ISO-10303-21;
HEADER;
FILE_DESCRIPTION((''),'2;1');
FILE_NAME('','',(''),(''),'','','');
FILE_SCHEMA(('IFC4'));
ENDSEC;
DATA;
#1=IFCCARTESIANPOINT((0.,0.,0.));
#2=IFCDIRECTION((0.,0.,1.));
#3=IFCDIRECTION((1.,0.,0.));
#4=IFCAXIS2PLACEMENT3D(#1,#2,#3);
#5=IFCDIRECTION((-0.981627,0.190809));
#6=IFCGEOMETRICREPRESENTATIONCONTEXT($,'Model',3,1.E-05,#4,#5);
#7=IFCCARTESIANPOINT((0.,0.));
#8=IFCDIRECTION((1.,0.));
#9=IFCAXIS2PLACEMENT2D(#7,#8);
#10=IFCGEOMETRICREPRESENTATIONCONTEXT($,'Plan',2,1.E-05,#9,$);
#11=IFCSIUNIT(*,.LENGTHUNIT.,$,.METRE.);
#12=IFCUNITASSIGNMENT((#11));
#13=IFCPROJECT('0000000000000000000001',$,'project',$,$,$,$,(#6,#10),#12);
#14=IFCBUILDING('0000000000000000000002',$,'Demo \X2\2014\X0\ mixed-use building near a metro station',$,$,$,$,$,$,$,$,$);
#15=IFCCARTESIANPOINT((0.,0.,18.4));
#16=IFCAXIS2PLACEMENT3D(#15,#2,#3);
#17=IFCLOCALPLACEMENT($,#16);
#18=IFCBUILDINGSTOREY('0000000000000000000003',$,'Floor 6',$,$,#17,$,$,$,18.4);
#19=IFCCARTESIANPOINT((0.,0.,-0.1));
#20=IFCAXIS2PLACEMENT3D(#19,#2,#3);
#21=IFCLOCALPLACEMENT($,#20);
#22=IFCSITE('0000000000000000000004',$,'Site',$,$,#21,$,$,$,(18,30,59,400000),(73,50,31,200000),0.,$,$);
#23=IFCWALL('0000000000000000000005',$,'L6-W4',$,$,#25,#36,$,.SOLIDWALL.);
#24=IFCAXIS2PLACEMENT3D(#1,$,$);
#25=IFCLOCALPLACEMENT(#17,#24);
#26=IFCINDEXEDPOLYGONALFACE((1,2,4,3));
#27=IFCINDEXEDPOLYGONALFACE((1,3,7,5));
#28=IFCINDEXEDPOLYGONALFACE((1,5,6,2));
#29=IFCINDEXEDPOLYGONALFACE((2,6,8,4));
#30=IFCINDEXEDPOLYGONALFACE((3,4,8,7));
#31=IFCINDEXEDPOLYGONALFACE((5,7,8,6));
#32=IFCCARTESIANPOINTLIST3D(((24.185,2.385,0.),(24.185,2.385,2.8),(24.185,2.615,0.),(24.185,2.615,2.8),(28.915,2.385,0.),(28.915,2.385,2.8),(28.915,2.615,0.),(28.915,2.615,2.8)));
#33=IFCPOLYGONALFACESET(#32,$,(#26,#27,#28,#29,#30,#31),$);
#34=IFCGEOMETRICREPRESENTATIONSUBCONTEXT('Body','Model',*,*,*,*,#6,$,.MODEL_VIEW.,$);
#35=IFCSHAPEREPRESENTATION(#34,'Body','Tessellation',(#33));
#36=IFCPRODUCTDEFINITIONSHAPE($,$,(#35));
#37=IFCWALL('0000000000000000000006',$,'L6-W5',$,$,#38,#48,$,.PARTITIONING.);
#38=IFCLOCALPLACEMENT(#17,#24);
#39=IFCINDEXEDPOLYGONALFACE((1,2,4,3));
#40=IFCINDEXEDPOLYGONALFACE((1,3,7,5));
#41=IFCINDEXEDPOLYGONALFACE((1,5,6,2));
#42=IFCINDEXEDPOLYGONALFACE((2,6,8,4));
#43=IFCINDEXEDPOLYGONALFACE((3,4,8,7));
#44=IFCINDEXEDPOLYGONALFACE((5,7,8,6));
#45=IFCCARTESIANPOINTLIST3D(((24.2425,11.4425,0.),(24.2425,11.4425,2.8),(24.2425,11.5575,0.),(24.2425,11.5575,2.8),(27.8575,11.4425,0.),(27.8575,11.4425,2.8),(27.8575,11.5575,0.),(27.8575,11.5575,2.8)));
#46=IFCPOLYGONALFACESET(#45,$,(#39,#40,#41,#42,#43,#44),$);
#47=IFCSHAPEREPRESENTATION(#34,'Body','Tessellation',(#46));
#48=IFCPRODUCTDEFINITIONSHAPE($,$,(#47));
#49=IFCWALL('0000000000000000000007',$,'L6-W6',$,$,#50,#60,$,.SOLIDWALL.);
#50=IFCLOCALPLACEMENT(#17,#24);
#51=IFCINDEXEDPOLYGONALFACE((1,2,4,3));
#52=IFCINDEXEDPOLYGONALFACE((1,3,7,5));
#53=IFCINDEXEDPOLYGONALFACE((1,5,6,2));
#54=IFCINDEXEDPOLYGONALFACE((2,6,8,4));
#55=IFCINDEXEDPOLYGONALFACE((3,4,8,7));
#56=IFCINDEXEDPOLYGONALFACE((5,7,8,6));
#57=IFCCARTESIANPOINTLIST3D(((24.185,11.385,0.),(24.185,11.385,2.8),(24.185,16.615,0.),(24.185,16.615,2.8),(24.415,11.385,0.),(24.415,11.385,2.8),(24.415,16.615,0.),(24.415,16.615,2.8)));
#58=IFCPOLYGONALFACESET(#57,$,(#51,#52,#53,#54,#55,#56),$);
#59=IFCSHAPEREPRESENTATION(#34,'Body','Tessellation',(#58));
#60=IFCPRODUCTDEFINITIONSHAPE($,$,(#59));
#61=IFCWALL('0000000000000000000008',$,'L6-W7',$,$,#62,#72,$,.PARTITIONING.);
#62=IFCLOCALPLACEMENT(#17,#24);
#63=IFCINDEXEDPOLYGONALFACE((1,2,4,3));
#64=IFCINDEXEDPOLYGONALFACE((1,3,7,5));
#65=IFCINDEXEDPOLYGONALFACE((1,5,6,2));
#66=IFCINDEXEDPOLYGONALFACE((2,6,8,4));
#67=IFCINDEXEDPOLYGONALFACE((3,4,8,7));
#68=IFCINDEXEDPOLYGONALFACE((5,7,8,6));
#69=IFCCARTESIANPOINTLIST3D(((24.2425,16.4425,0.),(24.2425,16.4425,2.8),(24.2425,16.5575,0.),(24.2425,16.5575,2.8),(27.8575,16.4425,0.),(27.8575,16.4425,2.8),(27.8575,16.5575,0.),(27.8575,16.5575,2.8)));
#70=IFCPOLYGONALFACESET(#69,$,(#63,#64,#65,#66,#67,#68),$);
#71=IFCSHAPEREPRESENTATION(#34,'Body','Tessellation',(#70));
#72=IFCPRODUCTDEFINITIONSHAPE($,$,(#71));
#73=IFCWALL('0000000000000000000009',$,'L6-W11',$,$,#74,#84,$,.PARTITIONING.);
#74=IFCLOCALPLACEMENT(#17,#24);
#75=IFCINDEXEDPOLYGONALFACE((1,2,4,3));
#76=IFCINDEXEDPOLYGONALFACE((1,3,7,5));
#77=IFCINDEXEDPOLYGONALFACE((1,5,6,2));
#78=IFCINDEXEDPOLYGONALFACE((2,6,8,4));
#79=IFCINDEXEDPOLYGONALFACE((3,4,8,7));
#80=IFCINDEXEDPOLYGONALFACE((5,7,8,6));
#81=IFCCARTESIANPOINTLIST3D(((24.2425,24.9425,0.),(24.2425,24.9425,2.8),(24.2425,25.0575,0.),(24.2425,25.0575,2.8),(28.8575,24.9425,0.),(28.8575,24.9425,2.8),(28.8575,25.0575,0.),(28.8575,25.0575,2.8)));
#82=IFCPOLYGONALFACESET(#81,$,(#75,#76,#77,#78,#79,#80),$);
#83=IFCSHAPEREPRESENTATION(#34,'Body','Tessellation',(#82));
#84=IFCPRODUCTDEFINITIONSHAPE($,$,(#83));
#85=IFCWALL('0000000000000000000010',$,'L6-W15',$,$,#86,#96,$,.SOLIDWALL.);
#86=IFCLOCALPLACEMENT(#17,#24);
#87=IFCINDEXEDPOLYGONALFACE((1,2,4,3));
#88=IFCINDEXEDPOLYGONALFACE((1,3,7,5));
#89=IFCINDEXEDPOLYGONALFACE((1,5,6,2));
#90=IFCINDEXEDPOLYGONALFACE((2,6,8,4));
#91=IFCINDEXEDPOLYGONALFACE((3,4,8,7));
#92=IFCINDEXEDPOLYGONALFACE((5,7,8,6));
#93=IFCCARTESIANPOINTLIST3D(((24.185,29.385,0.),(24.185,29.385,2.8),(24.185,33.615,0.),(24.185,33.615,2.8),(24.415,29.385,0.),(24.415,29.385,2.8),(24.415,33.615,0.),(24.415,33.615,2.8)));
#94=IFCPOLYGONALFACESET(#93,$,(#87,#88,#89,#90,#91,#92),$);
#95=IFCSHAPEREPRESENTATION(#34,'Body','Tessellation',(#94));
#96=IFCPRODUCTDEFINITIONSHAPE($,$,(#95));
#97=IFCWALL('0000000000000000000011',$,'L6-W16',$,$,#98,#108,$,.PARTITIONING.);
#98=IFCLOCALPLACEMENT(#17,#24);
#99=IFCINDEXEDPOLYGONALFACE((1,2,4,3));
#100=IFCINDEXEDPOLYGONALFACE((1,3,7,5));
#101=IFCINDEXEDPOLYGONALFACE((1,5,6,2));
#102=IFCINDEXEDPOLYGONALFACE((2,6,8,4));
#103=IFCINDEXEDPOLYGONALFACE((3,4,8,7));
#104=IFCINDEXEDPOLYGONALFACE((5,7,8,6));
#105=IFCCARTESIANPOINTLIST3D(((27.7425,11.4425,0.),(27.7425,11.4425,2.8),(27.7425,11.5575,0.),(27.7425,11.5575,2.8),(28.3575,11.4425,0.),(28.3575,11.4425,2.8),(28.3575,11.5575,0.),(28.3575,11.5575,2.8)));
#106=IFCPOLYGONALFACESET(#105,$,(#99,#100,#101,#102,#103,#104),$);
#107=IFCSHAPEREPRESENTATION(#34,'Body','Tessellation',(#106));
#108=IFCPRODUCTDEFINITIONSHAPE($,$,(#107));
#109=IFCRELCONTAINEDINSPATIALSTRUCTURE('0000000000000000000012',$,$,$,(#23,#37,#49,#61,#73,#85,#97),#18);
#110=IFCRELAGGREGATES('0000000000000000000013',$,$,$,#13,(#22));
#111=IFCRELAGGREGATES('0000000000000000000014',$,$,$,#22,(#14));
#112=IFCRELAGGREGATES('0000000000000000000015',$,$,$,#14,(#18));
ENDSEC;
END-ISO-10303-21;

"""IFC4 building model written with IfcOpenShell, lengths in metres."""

from ifc_helpers import new_model, si_unit, direction, frame, origin_with_axes, origin_2d_with_axis, place, context, subcontext, project, spatial, line, indexed_curve, outline, extrude, element, save


model = new_model("IFC4")

# Units and contexts
model_context = context("Model", 3, precision=1e-05, world=origin_with_axes(), true_north=direction((-0.981627, 0.190809)))
plan_context = context("Plan", 2, precision=1e-05, world=origin_2d_with_axis())
body_context = subcontext(model_context, "Body", "Model", "MODEL_VIEW")
ifc_project = project(units=[si_unit("LENGTHUNIT", "METRE")], contexts=[model_context, plan_context])

# Site, building, storey
site_placement = place(None, frame((0.0, 0.0, -0.1), z_axis=(0.0, 0.0, 1.0), x_axis=(1.0, 0.0, 0.0)))
site = spatial("IfcSite", under=ifc_project, at=site_placement, Name="Site", RefLatitude=(18, 30, 59, 400000), RefLongitude=(73, 50, 31, 200000), RefElevation=0.0)
building = spatial("IfcBuilding", under=site, Name="Demo — mixed-use building near a metro station")
storey_placement = place(None, frame((0.0, 0.0, 18.4), z_axis=(0.0, 0.0, 1.0), x_axis=(1.0, 0.0, 0.0)))
storey = spatial("IfcBuildingStorey", under=building, at=storey_placement, Name="Floor 6", Elevation=18.4)

# Walls
wall_1_placement = place(storey_placement, frame((0.0, 0.0, -18.4), z_axis=(0.0, 0.0, 1.0), x_axis=(1.0, 0.0, 0.0)))
element("IfcWall", 1, at=wall_1_placement, inside=storey, Name="L6-W4", PredefinedType="SOLIDWALL", context=body_context, shape_type="SweptSolid", body=[
    extrude(outline(indexed_curve([(24.185, 2.615), (28.915, 2.615), (28.915, 2.385), (24.185, 2.385)], segments=[line(1, 2, 3, 4, 1)])), frame((0.0, 0.0, 18.4), z_axis=(0.0, 0.0, 1.0), x_axis=(1.0, 0.0, 0.0)), (0.0, 0.0, 1.0), 2.8),
])
wall_2_placement = place(storey_placement, frame((0.0, 0.0, -18.4), z_axis=(0.0, 0.0, 1.0), x_axis=(1.0, 0.0, 0.0)))
element("IfcWall", 2, at=wall_2_placement, inside=storey, Name="L6-W5", PredefinedType="PARTITIONING", context=body_context, shape_type="SweptSolid", body=[
    extrude(outline(indexed_curve([(24.2425, 11.5575), (27.8575, 11.5575), (27.8575, 11.4425), (24.2425, 11.4425)], segments=[line(1, 2, 3, 4, 1)])), frame((0.0, 0.0, 18.4), z_axis=(0.0, 0.0, 1.0), x_axis=(1.0, 0.0, 0.0)), (0.0, 0.0, 1.0), 2.8),
])
wall_3_placement = place(storey_placement, frame((0.0, 0.0, -18.4), z_axis=(0.0, 0.0, 1.0), x_axis=(1.0, 0.0, 0.0)))
element("IfcWall", 3, at=wall_3_placement, inside=storey, Name="L6-W6", PredefinedType="SOLIDWALL", context=body_context, shape_type="SweptSolid", body=[
    extrude(outline(indexed_curve([(24.415, 16.615), (24.415, 11.385), (24.185, 11.385), (24.185, 16.615)], segments=[line(1, 2, 3, 4, 1)])), frame((0.0, 0.0, 18.4), z_axis=(0.0, 0.0, 1.0), x_axis=(1.0, 0.0, 0.0)), (0.0, 0.0, 1.0), 2.8),
])
wall_4_placement = place(storey_placement, frame((0.0, 0.0, -18.4), z_axis=(0.0, 0.0, 1.0), x_axis=(1.0, 0.0, 0.0)))
element("IfcWall", 4, at=wall_4_placement, inside=storey, Name="L6-W7", PredefinedType="PARTITIONING", context=body_context, shape_type="SweptSolid", body=[
    extrude(outline(indexed_curve([(27.8575, 16.4425), (24.2425, 16.4425), (24.2425, 16.5575), (27.8575, 16.5575)], segments=[line(1, 2, 3, 4, 1)])), frame((0.0, 0.0, 18.4), z_axis=(0.0, 0.0, 1.0), x_axis=(1.0, 0.0, 0.0)), (0.0, 0.0, 1.0), 2.8),
])

# Wall
wall_5_placement = place(storey_placement, frame((0.0, 0.0, -18.4), z_axis=(0.0, 0.0, 1.0), x_axis=(1.0, 0.0, 0.0)))
element("IfcWall", 5, at=wall_5_placement, inside=storey, Name="L6-W11", PredefinedType="PARTITIONING", context=body_context, shape_type="SweptSolid", body=[
    extrude(outline(indexed_curve([(28.8575, 24.9425), (24.2425, 24.9425), (24.2425, 25.0575), (28.8575, 25.0575)], segments=[line(1, 2, 3, 4, 1)])), frame((0.0, 0.0, 18.4), z_axis=(0.0, 0.0, 1.0), x_axis=(1.0, 0.0, 0.0)), (0.0, 0.0, 1.0), 2.8),
])

# Walls
wall_6_placement = place(storey_placement, frame((0.0, 0.0, -18.4), z_axis=(0.0, 0.0, 1.0), x_axis=(1.0, 0.0, 0.0)))
element("IfcWall", 6, at=wall_6_placement, inside=storey, Name="L6-W15", PredefinedType="SOLIDWALL", context=body_context, shape_type="SweptSolid", body=[
    extrude(outline(indexed_curve([(24.415, 33.615), (24.415, 29.385), (24.185, 29.385), (24.185, 33.615)], segments=[line(1, 2, 3, 4, 1)])), frame((0.0, 0.0, 18.4), z_axis=(0.0, 0.0, 1.0), x_axis=(1.0, 0.0, 0.0)), (0.0, 0.0, 1.0), 2.8),
])
wall_7_placement = place(storey_placement, frame((0.0, 0.0, -18.4), z_axis=(0.0, 0.0, 1.0), x_axis=(1.0, 0.0, 0.0)))
element("IfcWall", 7, at=wall_7_placement, inside=storey, Name="L6-W16", PredefinedType="PARTITIONING", context=body_context, shape_type="SweptSolid", body=[
    extrude(outline(indexed_curve([(27.7425, 11.5575), (28.3575, 11.5575), (28.3575, 11.4425), (27.7425, 11.4425)], segments=[line(1, 2, 3, 4, 1)])), frame((0.0, 0.0, 18.4), z_axis=(0.0, 0.0, 1.0), x_axis=(1.0, 0.0, 0.0)), (0.0, 0.0, 1.0), 2.8),
])

save(model, "model.ifc")
